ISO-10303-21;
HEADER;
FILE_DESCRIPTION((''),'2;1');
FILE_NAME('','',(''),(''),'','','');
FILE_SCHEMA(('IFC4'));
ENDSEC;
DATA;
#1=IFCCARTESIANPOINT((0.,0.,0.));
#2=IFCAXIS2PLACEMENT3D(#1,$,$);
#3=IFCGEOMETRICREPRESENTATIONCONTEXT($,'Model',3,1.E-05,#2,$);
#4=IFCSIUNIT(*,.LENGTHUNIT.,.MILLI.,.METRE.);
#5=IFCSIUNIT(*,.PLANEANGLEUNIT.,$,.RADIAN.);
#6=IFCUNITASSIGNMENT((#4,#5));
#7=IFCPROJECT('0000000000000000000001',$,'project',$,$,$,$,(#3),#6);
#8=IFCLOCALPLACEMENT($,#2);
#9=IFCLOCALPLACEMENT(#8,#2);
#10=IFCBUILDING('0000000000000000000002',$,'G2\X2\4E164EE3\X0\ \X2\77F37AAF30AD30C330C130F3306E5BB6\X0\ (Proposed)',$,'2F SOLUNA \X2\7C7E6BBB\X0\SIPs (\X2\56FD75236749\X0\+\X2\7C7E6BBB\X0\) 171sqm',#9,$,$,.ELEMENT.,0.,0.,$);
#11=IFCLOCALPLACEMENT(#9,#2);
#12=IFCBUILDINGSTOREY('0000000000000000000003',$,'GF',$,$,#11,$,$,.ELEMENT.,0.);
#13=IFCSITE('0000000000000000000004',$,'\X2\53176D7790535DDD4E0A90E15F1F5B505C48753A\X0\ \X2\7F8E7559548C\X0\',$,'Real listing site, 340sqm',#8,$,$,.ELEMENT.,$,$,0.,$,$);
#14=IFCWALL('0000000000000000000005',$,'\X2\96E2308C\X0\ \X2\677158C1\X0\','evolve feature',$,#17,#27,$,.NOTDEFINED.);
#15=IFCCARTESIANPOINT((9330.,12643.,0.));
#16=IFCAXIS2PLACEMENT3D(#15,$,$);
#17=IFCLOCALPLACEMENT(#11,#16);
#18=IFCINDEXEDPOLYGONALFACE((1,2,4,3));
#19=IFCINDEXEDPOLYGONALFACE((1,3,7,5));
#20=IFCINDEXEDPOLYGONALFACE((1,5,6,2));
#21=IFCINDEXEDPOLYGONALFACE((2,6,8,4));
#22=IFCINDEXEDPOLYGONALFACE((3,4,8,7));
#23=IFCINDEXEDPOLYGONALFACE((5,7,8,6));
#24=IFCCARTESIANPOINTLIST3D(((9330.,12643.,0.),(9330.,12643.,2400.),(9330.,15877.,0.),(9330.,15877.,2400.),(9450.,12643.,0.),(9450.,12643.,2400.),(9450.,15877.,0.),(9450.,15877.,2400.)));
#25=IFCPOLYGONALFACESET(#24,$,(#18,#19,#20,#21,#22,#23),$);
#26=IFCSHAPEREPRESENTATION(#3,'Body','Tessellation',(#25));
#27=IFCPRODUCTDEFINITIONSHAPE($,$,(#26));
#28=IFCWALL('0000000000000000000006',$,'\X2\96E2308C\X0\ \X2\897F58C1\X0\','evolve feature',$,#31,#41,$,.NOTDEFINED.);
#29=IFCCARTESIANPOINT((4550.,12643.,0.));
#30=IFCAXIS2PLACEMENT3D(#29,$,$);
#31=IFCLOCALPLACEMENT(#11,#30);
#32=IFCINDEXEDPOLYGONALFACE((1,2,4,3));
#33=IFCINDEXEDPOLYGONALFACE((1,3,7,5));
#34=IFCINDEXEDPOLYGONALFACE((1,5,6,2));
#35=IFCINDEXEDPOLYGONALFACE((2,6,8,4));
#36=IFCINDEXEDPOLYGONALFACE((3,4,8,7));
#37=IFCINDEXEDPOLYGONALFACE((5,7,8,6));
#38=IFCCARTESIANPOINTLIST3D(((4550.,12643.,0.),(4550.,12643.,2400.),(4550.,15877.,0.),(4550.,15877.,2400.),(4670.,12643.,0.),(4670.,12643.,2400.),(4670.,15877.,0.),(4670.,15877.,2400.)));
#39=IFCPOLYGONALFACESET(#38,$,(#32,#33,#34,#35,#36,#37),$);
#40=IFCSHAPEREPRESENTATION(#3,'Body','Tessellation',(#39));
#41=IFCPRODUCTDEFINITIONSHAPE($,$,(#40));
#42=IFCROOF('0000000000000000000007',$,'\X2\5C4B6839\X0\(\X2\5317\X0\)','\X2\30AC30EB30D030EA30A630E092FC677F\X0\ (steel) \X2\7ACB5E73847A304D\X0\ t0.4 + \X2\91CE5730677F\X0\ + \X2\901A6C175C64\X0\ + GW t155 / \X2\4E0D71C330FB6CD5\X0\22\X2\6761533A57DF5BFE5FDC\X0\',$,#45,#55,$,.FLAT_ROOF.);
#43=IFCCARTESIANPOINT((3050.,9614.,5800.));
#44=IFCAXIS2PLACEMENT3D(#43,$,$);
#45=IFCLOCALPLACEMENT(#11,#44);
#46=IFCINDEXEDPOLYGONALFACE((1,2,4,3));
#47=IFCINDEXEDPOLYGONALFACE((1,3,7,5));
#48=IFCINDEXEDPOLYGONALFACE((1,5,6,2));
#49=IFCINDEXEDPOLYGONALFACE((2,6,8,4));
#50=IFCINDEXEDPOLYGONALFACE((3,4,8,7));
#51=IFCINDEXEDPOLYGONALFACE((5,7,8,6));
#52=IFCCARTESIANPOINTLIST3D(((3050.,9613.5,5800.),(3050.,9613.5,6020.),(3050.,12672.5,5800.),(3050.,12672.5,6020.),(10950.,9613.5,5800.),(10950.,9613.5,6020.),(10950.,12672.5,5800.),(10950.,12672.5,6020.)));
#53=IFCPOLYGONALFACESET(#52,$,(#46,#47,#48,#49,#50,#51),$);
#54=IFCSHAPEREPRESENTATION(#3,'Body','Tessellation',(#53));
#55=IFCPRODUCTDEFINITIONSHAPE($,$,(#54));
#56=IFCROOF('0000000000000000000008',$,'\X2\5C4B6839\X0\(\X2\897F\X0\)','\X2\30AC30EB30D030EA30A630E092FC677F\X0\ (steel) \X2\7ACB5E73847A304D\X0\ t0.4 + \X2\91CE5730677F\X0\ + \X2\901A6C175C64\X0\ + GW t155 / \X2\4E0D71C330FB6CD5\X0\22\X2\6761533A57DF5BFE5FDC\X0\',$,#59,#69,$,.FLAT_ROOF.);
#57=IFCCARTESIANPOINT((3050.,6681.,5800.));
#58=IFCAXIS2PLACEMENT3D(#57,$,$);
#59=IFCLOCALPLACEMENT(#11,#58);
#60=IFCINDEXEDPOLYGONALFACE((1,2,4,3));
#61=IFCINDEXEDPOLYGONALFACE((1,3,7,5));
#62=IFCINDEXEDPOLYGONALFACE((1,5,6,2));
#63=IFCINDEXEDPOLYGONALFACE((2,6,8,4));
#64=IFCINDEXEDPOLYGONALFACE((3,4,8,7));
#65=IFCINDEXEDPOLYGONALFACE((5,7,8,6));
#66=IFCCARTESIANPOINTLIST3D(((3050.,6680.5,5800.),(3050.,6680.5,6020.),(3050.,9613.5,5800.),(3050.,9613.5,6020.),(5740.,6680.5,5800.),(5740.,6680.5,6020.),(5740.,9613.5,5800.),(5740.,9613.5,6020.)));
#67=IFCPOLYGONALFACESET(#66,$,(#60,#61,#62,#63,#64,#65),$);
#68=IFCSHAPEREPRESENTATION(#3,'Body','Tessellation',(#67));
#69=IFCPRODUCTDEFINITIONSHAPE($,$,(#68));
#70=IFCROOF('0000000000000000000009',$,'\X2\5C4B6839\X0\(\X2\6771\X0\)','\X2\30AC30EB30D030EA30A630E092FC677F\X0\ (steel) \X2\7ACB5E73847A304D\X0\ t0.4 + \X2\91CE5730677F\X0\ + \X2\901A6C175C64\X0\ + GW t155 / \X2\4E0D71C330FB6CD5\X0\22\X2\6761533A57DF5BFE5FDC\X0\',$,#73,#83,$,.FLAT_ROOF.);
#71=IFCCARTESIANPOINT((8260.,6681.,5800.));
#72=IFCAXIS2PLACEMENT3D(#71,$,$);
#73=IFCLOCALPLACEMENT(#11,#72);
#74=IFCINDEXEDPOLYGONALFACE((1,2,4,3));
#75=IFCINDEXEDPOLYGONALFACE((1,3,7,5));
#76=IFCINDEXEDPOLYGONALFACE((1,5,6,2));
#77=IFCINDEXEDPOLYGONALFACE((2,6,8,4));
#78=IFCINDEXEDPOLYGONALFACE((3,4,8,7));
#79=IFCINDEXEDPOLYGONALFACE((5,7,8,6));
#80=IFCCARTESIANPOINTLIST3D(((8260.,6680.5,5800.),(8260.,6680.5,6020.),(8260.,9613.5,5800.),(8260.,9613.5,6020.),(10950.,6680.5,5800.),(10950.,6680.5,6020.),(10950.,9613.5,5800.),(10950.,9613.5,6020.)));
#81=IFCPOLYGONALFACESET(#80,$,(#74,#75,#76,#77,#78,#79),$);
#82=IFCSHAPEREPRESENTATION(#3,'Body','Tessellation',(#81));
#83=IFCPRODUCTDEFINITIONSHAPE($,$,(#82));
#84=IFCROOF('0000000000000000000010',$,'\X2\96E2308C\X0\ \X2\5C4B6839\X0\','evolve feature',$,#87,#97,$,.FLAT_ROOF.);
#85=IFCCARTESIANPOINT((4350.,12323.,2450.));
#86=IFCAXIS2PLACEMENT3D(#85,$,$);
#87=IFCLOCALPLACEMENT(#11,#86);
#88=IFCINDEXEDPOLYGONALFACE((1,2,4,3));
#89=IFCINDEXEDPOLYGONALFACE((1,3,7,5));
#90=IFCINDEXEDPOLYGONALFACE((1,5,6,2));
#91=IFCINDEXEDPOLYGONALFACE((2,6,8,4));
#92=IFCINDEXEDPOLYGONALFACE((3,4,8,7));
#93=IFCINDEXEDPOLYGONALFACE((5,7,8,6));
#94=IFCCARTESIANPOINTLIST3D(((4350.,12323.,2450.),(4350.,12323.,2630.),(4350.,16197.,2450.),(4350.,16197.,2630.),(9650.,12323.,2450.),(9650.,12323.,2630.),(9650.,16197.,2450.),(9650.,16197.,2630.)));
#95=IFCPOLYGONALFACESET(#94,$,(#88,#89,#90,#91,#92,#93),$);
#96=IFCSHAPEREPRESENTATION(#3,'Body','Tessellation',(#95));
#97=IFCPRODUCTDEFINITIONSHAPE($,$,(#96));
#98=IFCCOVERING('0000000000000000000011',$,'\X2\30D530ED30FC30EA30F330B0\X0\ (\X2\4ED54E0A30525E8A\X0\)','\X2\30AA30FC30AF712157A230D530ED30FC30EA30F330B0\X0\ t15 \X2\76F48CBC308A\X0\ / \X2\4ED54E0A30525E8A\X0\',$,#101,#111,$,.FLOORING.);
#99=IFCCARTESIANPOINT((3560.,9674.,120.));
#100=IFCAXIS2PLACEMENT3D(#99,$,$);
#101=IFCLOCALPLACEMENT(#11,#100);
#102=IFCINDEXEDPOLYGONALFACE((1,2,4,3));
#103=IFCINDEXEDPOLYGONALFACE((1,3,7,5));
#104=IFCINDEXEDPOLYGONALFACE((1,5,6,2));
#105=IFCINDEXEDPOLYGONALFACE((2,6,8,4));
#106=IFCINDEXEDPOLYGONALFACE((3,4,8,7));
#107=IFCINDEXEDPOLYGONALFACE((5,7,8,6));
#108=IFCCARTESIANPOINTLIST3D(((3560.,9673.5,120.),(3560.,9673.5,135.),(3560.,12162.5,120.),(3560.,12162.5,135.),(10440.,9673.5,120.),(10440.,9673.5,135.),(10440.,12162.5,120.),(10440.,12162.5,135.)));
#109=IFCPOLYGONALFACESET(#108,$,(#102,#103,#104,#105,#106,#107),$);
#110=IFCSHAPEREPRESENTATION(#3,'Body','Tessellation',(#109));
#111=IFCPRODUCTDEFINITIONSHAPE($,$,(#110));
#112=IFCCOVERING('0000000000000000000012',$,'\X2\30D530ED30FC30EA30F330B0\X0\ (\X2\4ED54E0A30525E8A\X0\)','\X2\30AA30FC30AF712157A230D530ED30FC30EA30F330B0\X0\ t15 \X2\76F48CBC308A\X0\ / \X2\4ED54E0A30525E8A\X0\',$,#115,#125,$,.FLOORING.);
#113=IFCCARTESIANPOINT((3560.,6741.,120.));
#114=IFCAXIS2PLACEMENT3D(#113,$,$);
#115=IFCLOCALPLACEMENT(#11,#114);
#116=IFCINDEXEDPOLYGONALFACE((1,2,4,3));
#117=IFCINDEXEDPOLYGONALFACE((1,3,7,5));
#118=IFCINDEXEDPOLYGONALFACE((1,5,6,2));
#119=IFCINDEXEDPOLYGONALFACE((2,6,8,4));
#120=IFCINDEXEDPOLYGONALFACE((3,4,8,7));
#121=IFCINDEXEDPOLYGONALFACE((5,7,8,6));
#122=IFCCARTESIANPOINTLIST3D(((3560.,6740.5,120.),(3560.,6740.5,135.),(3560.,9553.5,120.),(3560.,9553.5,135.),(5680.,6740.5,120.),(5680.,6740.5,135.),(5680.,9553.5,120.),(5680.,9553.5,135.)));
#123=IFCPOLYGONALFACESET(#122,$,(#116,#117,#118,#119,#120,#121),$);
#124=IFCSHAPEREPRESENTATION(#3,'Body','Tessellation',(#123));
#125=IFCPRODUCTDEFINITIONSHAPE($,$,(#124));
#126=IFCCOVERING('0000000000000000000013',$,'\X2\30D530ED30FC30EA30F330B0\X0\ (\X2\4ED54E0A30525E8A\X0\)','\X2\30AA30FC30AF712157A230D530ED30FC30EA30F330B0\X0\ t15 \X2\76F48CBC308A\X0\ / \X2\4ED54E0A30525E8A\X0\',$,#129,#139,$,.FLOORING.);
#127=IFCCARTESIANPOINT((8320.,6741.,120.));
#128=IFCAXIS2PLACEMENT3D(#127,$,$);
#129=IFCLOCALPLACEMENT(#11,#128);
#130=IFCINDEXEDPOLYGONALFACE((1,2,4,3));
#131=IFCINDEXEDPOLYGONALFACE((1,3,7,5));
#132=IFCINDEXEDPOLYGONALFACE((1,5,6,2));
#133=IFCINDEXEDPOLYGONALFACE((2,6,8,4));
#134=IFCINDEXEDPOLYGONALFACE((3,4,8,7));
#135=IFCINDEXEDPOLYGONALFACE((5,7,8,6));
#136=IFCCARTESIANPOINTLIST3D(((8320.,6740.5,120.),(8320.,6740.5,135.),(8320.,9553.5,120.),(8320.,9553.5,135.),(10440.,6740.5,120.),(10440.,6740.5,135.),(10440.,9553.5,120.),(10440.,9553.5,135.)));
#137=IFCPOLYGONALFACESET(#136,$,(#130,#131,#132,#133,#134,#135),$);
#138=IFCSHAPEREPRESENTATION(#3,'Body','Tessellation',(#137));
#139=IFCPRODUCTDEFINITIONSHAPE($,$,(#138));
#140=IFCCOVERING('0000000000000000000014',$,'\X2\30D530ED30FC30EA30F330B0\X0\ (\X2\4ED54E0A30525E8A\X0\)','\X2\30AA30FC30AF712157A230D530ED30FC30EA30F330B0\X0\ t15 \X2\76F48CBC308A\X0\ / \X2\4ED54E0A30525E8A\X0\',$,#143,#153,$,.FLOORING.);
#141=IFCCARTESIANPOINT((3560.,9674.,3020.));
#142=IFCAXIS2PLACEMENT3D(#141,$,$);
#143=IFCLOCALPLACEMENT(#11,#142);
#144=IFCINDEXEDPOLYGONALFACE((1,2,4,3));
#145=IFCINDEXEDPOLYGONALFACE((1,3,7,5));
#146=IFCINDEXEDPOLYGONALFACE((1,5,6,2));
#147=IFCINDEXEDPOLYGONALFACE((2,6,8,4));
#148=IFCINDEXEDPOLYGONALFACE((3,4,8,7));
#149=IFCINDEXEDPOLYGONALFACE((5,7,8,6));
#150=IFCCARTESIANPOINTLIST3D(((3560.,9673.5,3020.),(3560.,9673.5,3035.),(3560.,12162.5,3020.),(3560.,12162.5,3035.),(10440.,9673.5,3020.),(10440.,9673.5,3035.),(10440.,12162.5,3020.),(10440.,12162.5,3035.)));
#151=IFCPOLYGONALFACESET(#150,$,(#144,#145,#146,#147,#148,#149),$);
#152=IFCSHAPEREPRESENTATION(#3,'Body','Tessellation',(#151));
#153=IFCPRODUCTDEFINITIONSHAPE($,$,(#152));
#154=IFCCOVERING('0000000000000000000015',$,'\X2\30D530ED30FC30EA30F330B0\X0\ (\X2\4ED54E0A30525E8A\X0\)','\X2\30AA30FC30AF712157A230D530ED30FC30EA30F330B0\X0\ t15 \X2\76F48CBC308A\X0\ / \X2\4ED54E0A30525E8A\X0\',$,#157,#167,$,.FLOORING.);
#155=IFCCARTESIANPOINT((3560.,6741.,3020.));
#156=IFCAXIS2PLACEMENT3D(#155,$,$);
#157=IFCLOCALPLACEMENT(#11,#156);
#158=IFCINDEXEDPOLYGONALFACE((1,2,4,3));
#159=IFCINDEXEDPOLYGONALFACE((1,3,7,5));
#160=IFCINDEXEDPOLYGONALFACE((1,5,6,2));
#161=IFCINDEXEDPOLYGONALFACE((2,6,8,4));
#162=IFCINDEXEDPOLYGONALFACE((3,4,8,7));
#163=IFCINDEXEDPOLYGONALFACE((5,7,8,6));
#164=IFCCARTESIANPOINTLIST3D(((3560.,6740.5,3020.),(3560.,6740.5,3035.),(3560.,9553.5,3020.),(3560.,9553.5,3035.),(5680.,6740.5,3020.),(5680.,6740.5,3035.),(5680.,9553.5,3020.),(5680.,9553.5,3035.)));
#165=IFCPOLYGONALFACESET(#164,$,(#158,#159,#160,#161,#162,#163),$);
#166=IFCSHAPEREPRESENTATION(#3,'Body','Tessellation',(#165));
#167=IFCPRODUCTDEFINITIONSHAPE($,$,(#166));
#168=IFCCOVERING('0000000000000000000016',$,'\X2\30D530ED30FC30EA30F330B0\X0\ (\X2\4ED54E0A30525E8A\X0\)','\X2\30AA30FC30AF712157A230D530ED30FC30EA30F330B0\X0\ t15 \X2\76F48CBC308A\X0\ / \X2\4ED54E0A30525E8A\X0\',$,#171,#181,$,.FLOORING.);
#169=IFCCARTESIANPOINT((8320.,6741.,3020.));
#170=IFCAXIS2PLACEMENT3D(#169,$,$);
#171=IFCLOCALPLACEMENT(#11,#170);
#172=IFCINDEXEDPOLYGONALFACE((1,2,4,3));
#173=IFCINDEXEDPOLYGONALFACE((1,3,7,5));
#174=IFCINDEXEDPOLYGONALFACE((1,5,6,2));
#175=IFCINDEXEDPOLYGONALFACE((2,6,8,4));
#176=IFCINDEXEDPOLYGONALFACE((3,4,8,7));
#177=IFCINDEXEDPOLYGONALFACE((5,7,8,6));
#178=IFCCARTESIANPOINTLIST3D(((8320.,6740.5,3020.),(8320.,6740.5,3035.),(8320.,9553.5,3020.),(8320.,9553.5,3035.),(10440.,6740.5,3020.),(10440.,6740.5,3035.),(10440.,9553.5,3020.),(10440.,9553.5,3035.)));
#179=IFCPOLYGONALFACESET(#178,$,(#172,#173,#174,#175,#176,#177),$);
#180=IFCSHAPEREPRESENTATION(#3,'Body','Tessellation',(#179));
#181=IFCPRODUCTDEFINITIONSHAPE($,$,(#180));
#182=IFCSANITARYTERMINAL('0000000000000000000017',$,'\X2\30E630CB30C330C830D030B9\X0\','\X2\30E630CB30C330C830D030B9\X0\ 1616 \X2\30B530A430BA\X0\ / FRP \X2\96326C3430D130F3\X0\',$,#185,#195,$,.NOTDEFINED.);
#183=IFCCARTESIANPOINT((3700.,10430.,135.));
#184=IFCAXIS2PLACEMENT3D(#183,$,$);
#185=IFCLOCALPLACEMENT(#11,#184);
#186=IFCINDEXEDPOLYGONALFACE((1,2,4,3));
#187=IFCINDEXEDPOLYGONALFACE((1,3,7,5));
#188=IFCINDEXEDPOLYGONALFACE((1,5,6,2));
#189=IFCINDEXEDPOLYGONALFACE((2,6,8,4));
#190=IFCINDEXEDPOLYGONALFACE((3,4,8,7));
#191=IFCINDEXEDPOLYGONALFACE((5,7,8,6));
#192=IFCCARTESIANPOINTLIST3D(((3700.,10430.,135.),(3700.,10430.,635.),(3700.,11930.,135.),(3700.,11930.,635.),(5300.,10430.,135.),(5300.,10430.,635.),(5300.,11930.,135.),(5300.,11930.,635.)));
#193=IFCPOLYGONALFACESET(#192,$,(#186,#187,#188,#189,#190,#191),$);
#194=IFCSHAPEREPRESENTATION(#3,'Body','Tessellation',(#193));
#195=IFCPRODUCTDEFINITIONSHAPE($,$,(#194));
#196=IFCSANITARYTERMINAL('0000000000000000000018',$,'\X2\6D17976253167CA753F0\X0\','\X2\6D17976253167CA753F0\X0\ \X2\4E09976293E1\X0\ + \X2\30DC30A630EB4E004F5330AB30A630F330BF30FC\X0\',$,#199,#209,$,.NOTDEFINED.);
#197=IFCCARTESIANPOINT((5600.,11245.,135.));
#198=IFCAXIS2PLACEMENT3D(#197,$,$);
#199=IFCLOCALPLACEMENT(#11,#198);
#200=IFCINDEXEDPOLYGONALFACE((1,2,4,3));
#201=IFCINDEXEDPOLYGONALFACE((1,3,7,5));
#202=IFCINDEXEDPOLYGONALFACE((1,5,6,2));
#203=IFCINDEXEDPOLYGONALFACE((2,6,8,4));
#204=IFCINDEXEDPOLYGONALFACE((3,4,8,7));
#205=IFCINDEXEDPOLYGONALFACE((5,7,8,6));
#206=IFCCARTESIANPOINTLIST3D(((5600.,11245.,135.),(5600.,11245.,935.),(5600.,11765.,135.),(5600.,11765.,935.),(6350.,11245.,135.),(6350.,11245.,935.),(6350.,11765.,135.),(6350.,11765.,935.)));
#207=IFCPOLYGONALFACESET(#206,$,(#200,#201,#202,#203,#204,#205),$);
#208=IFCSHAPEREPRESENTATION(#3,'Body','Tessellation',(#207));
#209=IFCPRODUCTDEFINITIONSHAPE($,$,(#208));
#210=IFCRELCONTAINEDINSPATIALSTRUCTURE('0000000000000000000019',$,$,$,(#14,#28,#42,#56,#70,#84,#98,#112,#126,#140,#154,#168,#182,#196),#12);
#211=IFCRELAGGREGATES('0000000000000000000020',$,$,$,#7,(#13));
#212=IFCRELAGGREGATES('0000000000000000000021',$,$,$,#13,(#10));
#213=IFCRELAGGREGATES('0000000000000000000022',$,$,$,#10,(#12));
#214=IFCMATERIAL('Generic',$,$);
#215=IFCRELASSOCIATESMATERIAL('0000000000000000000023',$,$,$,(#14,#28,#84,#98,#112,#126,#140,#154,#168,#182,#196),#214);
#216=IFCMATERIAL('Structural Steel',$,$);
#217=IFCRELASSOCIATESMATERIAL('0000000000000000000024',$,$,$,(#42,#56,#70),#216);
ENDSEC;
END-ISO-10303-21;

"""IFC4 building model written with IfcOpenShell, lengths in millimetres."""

from ifc_helpers import new_model, si_unit, frame, frame_2d, origin, place, context, project, spatial, rectangle, extrude, material, element, save


model = new_model("IFC4")

# Units and contexts
model_context = context("Model", 3, precision=1e-05, world=origin())
ifc_project = project(units=[si_unit("LENGTHUNIT", "METRE", prefix="MILLI"), si_unit("PLANEANGLEUNIT", "RADIAN")], contexts=[model_context])

# Site, building, storey
site_placement = place(None, origin())
site = spatial("IfcSite", under=ifc_project, at=site_placement, Name="北海道川上郡弟子屈町 美留和", ObjectType="Real listing site, 340sqm", CompositionType="ELEMENT", RefElevation=0.0)
building_placement = place(site_placement, origin())
building = spatial("IfcBuilding", under=site, at=building_placement, Name="G2世代 石窯キッチンの家 (Proposed)", ObjectType="2F SOLUNA 籾殻SIPs (国産杉+籾殻) 171sqm", CompositionType="ELEMENT", ElevationOfRefHeight=0.0, ElevationOfTerrain=0.0)
storey_placement = place(building_placement, origin())
storey = spatial("IfcBuildingStorey", under=building, at=storey_placement, Name="GF", CompositionType="ELEMENT", Elevation=0.0)

# Shared definitions
ifc_material_1 = material(Name="Generic")

# Walls
wall_1_placement = place(storey_placement, frame((9330.0, 12643.0, 0.0)))
element("IfcWall", 1, at=wall_1_placement, inside=storey, material=ifc_material_1, Name="離れ 東壁", Description="evolve feature", PredefinedType="NOTDEFINED", context=model_context, shape_type="SweptSolid", body=[
    extrude(rectangle(XDim=120.0, YDim=3234.0, at=frame_2d((60.0, 1617.0))), frame((9330.0, 12643.0, 0.0)), (0.0, 0.0, 1.0), 2400.0),
])
wall_2_placement = place(storey_placement, frame((4550.0, 12643.0, 0.0)))
element("IfcWall", 2, at=wall_2_placement, inside=storey, material=ifc_material_1, Name="離れ 西壁", Description="evolve feature", PredefinedType="NOTDEFINED", context=model_context, shape_type="SweptSolid", body=[
    extrude(rectangle(XDim=120.0, YDim=3234.0, at=frame_2d((60.0, 1617.0))), frame((4550.0, 12643.0, 0.0)), (0.0, 0.0, 1.0), 2400.0),
])

# Roofs
ifc_material_2 = material(Name="Structural Steel")
for number, where, name in (
    (3, (3050.0, 9614.0, 5800.0), "屋根(北)"),
):
    element("IfcRoof", number, at=place(storey_placement, frame(where)), inside=storey, material=ifc_material_2, Name=name, Description="ガルバリウム鋼板 (steel) 立平葺き t0.4 + 野地板 + 通気層 + GW t155 / 不燃・法22条区域対応", PredefinedType="FLAT_ROOF", context=model_context, shape_type="SweptSolid", body=[
        extrude(rectangle(XDim=7900.0, YDim=3059.0, at=frame_2d((3950.0, 1529.0))), frame((3050.0, 9614.0, 5800.0)), (0.0, 0.0, 1.0), 220.0),
    ])
roof_1_placement = place(storey_placement, frame((3050.0, 6681.0, 5800.0)))
element("IfcRoof", 4, at=roof_1_placement, inside=storey, material=ifc_material_2, Name="屋根(西)", Description="ガルバリウム鋼板 (steel) 立平葺き t0.4 + 野地板 + 通気層 + GW t155 / 不燃・法22条区域対応", PredefinedType="FLAT_ROOF", context=model_context, shape_type="SweptSolid", body=[
    extrude(rectangle(XDim=2690.0, YDim=2933.0, at=frame_2d((1345.0, 1466.0))), frame((3050.0, 6681.0, 5800.0)), (0.0, 0.0, 1.0), 220.0),
])
roof_2_placement = place(storey_placement, frame((8260.0, 6681.0, 5800.0)))
element("IfcRoof", 5, at=roof_2_placement, inside=storey, material=ifc_material_2, Name="屋根(東)", Description="ガルバリウム鋼板 (steel) 立平葺き t0.4 + 野地板 + 通気層 + GW t155 / 不燃・法22条区域対応", PredefinedType="FLAT_ROOF", context=model_context, shape_type="SweptSolid", body=[
    extrude(rectangle(XDim=2690.0, YDim=2933.0, at=frame_2d((1345.0, 1466.0))), frame((8260.0, 6681.0, 5800.0)), (0.0, 0.0, 1.0), 220.0),
])
roof_3_placement = place(storey_placement, frame((4350.0, 12323.0, 2450.0)))
element("IfcRoof", 6, at=roof_3_placement, inside=storey, material=ifc_material_1, Name="離れ 屋根", Description="evolve feature", PredefinedType="FLAT_ROOF", context=model_context, shape_type="SweptSolid", body=[
    extrude(rectangle(XDim=5300.0, YDim=3874.0, at=frame_2d((2650.0, 1937.0))), frame((4350.0, 12323.0, 2450.0)), (0.0, 0.0, 1.0), 180.0),
])

# Coverings
covering_1_placement = place(storey_placement, frame((3560.0, 9674.0, 120.0)))
element("IfcCovering", 7, at=covering_1_placement, inside=storey, material=ifc_material_1, Name="フローリング (仕上げ床)", Description="オーク無垢フローリング t15 直貼り / 仕上げ床", PredefinedType="FLOORING", context=model_context, shape_type="SweptSolid", body=[
    extrude(rectangle(XDim=6880.0, YDim=2489.0, at=frame_2d((3440.0, 1244.0))), frame((3560.0, 9674.0, 120.0)), (0.0, 0.0, 1.0), 15.0),
])
covering_2_placement = place(storey_placement, frame((3560.0, 6741.0, 120.0)))
element("IfcCovering", 8, at=covering_2_placement, inside=storey, material=ifc_material_1, Name="フローリング (仕上げ床)", Description="オーク無垢フローリング t15 直貼り / 仕上げ床", PredefinedType="FLOORING", context=model_context, shape_type="SweptSolid", body=[
    extrude(rectangle(XDim=2120.0, YDim=2813.0, at=frame_2d((1060.0, 1406.0))), frame((3560.0, 6741.0, 120.0)), (0.0, 0.0, 1.0), 15.0),
])
covering_3_placement = place(storey_placement, frame((8320.0, 6741.0, 120.0)))
element("IfcCovering", 9, at=covering_3_placement, inside=storey, material=ifc_material_1, Name="フローリング (仕上げ床)", Description="オーク無垢フローリング t15 直貼り / 仕上げ床", PredefinedType="FLOORING", context=model_context, shape_type="SweptSolid", body=[
    extrude(rectangle(XDim=2120.0, YDim=2813.0, at=frame_2d((1060.0, 1406.0))), frame((8320.0, 6741.0, 120.0)), (0.0, 0.0, 1.0), 15.0),
])
covering_4_placement = place(storey_placement, frame((3560.0, 9674.0, 3020.0)))
element("IfcCovering", 10, at=covering_4_placement, inside=storey, material=ifc_material_1, Name="フローリング (仕上げ床)", Description="オーク無垢フローリング t15 直貼り / 仕上げ床", PredefinedType="FLOORING", context=model_context, shape_type="SweptSolid", body=[
    extrude(rectangle(XDim=6880.0, YDim=2489.0, at=frame_2d((3440.0, 1244.0))), frame((3560.0, 9674.0, 3020.0)), (0.0, 0.0, 1.0), 15.0),
])
covering_5_placement = place(storey_placement, frame((3560.0, 6741.0, 3020.0)))
element("IfcCovering", 11, at=covering_5_placement, inside=storey, material=ifc_material_1, Name="フローリング (仕上げ床)", Description="オーク無垢フローリング t15 直貼り / 仕上げ床", PredefinedType="FLOORING", context=model_context, shape_type="SweptSolid", body=[
    extrude(rectangle(XDim=2120.0, YDim=2813.0, at=frame_2d((1060.0, 1406.0))), frame((3560.0, 6741.0, 3020.0)), (0.0, 0.0, 1.0), 15.0),
])
covering_6_placement = place(storey_placement, frame((8320.0, 6741.0, 3020.0)))
element("IfcCovering", 12, at=covering_6_placement, inside=storey, material=ifc_material_1, Name="フローリング (仕上げ床)", Description="オーク無垢フローリング t15 直貼り / 仕上げ床", PredefinedType="FLOORING", context=model_context, shape_type="SweptSolid", body=[
    extrude(rectangle(XDim=2120.0, YDim=2813.0, at=frame_2d((1060.0, 1406.0))), frame((8320.0, 6741.0, 3020.0)), (0.0, 0.0, 1.0), 15.0),
])

# Sanitary terminals
sanitary_terminal_1_placement = place(storey_placement, frame((3700.0, 10430.0, 135.0)))
element("IfcSanitaryTerminal", 13, at=sanitary_terminal_1_placement, inside=storey, material=ifc_material_1, Name="ユニットバス", Description="ユニットバス 1616 サイズ / FRP 防水パン", PredefinedType="NOTDEFINED", context=model_context, shape_type="SweptSolid", body=[
    extrude(rectangle(XDim=1600.0, YDim=1500.0, at=frame_2d((800.0, 750.0))), frame((3700.0, 10430.0, 135.0)), (0.0, 0.0, 1.0), 500.0),
])
sanitary_terminal_2_placement = place(storey_placement, frame((5600.0, 11245.0, 135.0)))
element("IfcSanitaryTerminal", 14, at=sanitary_terminal_2_placement, inside=storey, material=ifc_material_1, Name="洗面化粧台", Description="洗面化粧台 三面鏡 + ボウル一体カウンター", PredefinedType="NOTDEFINED", context=model_context, shape_type="SweptSolid", body=[
    extrude(rectangle(XDim=750.0, YDim=520.0, at=frame_2d((375.0, 260.0))), frame((5600.0, 11245.0, 135.0)), (0.0, 0.0, 1.0), 800.0),
])

save(model, "model.ifc")
